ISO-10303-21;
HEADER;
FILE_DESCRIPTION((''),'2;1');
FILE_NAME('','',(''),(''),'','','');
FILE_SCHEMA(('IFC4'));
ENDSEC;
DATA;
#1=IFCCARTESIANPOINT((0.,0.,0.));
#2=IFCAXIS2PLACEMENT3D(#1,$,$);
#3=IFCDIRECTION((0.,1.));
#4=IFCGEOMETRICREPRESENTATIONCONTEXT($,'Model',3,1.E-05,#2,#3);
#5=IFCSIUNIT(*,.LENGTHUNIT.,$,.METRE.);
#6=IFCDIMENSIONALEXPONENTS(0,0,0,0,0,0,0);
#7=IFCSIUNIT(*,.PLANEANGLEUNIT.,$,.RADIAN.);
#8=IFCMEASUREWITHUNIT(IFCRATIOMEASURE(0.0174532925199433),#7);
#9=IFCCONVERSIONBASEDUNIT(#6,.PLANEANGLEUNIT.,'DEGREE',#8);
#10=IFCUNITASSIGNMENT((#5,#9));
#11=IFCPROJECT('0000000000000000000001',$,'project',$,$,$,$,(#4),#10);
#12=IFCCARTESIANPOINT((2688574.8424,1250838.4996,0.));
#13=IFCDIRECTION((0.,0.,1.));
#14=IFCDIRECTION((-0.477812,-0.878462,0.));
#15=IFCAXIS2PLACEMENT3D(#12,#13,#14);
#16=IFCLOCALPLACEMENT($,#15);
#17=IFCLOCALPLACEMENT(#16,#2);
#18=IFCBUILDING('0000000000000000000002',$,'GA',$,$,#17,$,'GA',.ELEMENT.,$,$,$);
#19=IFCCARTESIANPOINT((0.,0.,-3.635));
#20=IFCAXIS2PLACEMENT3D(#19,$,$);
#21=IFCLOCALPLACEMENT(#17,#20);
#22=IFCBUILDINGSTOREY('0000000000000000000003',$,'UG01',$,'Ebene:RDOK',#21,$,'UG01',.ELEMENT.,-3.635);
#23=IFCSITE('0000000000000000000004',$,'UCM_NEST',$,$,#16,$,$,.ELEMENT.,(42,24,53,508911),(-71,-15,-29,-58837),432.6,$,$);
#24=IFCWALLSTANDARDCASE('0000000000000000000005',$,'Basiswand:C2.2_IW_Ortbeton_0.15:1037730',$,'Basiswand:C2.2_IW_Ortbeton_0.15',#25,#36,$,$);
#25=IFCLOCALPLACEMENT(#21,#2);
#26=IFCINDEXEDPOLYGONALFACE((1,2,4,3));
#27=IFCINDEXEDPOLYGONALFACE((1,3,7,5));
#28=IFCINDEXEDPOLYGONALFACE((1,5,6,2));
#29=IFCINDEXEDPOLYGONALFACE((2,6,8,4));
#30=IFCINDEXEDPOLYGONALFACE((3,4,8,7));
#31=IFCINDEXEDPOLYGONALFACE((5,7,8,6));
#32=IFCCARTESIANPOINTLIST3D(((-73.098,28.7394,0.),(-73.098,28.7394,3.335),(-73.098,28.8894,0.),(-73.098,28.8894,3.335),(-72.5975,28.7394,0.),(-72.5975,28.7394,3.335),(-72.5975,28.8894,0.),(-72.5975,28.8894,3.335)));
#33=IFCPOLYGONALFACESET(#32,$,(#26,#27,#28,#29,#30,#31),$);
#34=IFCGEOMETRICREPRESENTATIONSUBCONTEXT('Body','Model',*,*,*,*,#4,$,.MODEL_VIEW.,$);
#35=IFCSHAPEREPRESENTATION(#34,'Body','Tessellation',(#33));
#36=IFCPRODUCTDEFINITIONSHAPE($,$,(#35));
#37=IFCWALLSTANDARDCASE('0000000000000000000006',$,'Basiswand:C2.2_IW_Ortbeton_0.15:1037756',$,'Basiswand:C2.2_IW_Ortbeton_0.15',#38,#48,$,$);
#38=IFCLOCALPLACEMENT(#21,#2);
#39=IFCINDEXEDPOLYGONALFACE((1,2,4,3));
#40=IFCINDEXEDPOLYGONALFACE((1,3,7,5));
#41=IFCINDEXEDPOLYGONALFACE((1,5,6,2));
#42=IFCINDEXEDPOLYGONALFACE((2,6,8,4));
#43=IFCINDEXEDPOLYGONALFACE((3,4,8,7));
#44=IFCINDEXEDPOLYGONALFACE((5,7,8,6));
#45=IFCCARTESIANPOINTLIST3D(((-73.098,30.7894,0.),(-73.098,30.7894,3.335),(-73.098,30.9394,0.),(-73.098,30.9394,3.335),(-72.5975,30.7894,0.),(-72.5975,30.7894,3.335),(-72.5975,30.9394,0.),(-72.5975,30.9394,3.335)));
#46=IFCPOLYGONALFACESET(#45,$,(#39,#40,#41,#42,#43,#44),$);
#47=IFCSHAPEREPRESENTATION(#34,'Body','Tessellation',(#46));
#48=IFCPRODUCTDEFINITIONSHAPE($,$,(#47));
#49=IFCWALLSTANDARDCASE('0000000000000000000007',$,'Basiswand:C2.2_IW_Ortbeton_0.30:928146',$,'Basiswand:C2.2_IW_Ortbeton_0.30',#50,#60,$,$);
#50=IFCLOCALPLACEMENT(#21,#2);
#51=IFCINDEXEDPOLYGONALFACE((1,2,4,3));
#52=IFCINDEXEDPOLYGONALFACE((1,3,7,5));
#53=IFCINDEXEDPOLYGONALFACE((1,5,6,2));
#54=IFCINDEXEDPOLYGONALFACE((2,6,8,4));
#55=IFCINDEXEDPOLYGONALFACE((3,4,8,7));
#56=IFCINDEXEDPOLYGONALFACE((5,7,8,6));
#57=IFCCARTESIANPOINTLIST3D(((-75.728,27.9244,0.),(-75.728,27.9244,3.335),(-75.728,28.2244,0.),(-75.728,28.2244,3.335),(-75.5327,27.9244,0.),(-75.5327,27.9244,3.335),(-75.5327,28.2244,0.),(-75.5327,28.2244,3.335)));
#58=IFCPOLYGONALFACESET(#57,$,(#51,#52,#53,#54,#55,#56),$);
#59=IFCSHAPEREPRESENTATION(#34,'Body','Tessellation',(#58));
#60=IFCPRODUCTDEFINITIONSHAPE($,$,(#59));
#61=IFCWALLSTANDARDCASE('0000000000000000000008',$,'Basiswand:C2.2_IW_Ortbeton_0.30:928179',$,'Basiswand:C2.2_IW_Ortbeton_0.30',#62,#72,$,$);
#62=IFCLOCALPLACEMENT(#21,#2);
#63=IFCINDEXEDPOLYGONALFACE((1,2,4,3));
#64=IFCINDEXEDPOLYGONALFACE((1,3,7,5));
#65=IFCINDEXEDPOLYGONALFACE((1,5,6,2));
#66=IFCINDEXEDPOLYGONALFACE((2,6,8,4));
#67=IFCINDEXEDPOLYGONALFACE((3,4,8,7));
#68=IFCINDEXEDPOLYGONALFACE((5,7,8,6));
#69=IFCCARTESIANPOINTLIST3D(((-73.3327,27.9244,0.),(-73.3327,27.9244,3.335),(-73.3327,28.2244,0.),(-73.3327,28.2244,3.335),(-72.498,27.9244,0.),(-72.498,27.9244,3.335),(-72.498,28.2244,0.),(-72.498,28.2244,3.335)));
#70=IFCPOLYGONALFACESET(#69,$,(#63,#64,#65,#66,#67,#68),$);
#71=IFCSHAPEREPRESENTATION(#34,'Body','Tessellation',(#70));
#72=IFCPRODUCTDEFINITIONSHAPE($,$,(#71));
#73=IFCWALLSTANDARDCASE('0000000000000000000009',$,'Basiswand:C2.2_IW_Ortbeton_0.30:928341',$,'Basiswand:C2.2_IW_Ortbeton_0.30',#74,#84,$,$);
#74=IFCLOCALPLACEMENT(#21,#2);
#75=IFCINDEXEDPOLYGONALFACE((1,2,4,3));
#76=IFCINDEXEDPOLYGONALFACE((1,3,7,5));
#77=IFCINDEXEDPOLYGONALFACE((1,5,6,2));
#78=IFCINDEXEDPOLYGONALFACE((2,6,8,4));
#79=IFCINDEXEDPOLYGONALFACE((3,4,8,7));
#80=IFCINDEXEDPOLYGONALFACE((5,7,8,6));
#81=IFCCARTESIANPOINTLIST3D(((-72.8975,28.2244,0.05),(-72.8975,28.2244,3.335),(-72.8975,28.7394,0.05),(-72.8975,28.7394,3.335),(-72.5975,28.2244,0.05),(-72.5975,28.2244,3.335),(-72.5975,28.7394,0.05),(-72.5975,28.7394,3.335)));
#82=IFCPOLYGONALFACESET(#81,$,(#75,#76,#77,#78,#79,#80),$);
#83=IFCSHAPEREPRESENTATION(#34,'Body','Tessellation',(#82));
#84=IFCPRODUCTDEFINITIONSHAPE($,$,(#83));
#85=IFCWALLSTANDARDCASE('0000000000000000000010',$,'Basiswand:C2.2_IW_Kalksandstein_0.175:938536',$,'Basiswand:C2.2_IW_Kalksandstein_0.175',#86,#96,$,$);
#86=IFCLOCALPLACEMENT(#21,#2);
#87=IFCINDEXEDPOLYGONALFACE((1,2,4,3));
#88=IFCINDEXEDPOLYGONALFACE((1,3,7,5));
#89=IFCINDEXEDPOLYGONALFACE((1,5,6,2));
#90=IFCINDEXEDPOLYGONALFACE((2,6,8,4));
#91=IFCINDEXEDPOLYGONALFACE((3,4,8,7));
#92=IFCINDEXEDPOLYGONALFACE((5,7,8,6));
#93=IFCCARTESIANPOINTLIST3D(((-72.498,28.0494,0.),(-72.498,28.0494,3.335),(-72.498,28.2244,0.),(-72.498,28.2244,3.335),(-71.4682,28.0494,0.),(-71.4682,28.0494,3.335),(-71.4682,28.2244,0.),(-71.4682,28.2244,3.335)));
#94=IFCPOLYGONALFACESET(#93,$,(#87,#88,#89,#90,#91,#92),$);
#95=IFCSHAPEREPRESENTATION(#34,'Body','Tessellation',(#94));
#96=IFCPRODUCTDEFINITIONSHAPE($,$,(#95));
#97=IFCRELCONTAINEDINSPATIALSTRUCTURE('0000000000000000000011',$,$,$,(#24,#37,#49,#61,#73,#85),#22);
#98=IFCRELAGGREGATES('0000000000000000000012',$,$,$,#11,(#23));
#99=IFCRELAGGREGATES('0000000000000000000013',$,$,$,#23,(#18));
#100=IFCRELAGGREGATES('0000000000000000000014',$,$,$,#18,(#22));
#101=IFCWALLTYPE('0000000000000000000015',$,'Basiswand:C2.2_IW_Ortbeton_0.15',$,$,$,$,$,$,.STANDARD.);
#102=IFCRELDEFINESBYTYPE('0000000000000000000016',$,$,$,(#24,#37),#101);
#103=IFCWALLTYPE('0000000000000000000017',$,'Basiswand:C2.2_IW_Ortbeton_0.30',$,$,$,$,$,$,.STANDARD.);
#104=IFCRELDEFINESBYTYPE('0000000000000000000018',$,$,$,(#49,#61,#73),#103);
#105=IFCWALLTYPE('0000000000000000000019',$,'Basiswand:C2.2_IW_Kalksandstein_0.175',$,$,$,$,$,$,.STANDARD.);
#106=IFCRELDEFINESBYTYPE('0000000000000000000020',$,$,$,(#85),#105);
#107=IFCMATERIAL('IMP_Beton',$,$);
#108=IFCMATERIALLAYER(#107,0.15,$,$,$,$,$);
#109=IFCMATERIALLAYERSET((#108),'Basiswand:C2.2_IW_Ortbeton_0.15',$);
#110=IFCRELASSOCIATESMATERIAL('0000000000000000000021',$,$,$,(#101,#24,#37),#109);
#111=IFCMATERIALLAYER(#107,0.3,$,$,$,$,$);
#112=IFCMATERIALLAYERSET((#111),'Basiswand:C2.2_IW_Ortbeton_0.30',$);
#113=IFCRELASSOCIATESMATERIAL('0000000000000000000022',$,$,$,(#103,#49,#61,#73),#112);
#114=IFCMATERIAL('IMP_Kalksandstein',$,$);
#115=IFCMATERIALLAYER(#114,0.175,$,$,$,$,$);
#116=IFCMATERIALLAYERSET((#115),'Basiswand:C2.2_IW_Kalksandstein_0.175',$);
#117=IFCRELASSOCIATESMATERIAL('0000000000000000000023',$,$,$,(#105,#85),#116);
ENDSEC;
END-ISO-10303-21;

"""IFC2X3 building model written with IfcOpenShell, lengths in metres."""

from ifc_helpers import new_model, entity, si_unit, converted_unit, direction, frame, frame_2d, origin, place, context, subcontext, project, spatial, polyline, rectangle, extrude, clip, bounded_halfspace, material, layer, layer_set, layer_usage, type_object, element, save


model = new_model("IFC2X3")

# Units and contexts
model_context = context("Model", 3, precision=1e-05, world=origin(), true_north=direction((0.0, 1.0)))
body_context = subcontext(model_context, "Body", "Model", "MODEL_VIEW")
ifc_project = project(units=[si_unit("LENGTHUNIT", "METRE"), converted_unit("PLANEANGLEUNIT", "DEGREE", entity("IfcRatioMeasure", 0.0174532925199433), si_unit("PLANEANGLEUNIT", "RADIAN"), dimensions=[0, 0, 0, 0, 0, 0, 0])], contexts=[model_context])

# Site, building, storey
site_placement = place(None, frame((2688574.8424, 1250838.4996, 0.0), z_axis=(0.0, 0.0, 1.0), x_axis=(-0.477812, -0.878462, 0.0)))
site = spatial("IfcSite", under=ifc_project, at=site_placement, Name="UCM_NEST", CompositionType="ELEMENT", RefLatitude=(42, 24, 53, 508911), RefLongitude=(-71, -15, -29, -58837), RefElevation=432.6)
building_placement = place(site_placement, origin())
building = spatial("IfcBuilding", under=site, at=building_placement, Name="GA", LongName="GA", CompositionType="ELEMENT")
storey_placement = place(building_placement, frame((0.0, 0.0, -3.635)))
storey = spatial("IfcBuildingStorey", under=building, at=storey_placement, Name="UG01", ObjectType="Ebene:RDOK", LongName="UG01", CompositionType="ELEMENT", Elevation=-3.635)

# Shared definitions
ifc_material_1 = material(Name="IMP_Beton")

# Shared definitions
ifc_layer_1 = layer(ifc_material_1, 0.15)
ifc_layer_set_1 = layer_set([ifc_layer_1], Name="Basiswand:C2.2_IW_Ortbeton_0.15")
wall_type_1 = type_object("IfcWallType", Name="Basiswand:C2.2_IW_Ortbeton_0.15", PredefinedType="STANDARD", material=ifc_layer_set_1)

# Walls
ifc_layer_usage_1 = layer_usage(ifc_layer_set_1, "AXIS2", "NEGATIVE", 0.075)
wall_1_placement = place(storey_placement, frame((-72.5975, 28.8144, 0.0), z_axis=(0.0, 0.0, 1.0), x_axis=(-1.0, 0.0, 0.0)))
element("IfcWallStandardCase", 1, at=wall_1_placement, inside=storey, type_object=wall_type_1, material=ifc_layer_usage_1, Name="Basiswand:C2.2_IW_Ortbeton_0.15:1037730", ObjectType="Basiswand:C2.2_IW_Ortbeton_0.15", context=body_context, shape_type="SweptSolid", body=[
    extrude(rectangle(XDim=0.5005, YDim=0.15, at=frame_2d((0.2503, 0.0), x_axis=(-1.0, 0.0))), origin(), (0.0, 0.0, 1.0), 3.335),
])
ifc_layer_usage_2 = layer_usage(ifc_layer_set_1, "AXIS2", "NEGATIVE", 0.075)
wall_2_placement = place(storey_placement, frame((-73.098, 30.8644, 0.0)))
element("IfcWallStandardCase", 2, at=wall_2_placement, inside=storey, type_object=wall_type_1, material=ifc_layer_usage_2, Name="Basiswand:C2.2_IW_Ortbeton_0.15:1037756", ObjectType="Basiswand:C2.2_IW_Ortbeton_0.15", context=body_context, shape_type="SweptSolid", body=[
    extrude(rectangle(XDim=0.5005, YDim=0.15, at=frame_2d((0.2503, 0.0), x_axis=(-1.0, 0.0))), origin(), (0.0, 0.0, 1.0), 3.335),
])

# Walls
ifc_layer_2 = layer(ifc_material_1, 0.3)
ifc_layer_set_2 = layer_set([ifc_layer_2], Name="Basiswand:C2.2_IW_Ortbeton_0.30")
ifc_layer_usage_3 = layer_usage(ifc_layer_set_2, "AXIS2", "NEGATIVE", 0.15)
wall_type_2 = type_object("IfcWallType", Name="Basiswand:C2.2_IW_Ortbeton_0.30", PredefinedType="STANDARD", material=ifc_layer_set_2)
wall_3_placement = place(storey_placement, frame((-75.728, 28.0744, 0.0)))
element("IfcWallStandardCase", 3, at=wall_3_placement, inside=storey, type_object=wall_type_2, material=ifc_layer_usage_3, Name="Basiswand:C2.2_IW_Ortbeton_0.30:928146", ObjectType="Basiswand:C2.2_IW_Ortbeton_0.30", context=body_context, shape_type="SweptSolid", body=[
    extrude(rectangle(XDim=0.1953, YDim=0.3, at=frame_2d((0.0976, 0.0), x_axis=(-1.0, 0.0))), origin(), (0.0, 0.0, 1.0), 3.335),
])
ifc_layer_usage_4 = layer_usage(ifc_layer_set_2, "AXIS2", "NEGATIVE", 0.15)
wall_4_placement = place(storey_placement, frame((-73.3327, 28.0744, 0.0)))
element("IfcWallStandardCase", 4, at=wall_4_placement, inside=storey, type_object=wall_type_2, material=ifc_layer_usage_4, Name="Basiswand:C2.2_IW_Ortbeton_0.30:928179", ObjectType="Basiswand:C2.2_IW_Ortbeton_0.30", context=body_context, shape_type="SweptSolid", body=[
    extrude(rectangle(XDim=0.8347, YDim=0.3, at=frame_2d((0.4174, 0.0), x_axis=(-1.0, 0.0))), origin(), (0.0, 0.0, 1.0), 3.335),
])
ifc_layer_usage_5 = layer_usage(ifc_layer_set_2, "AXIS2", "NEGATIVE", 0.15)
wall_5_placement = place(storey_placement, frame((-72.7475, 28.7394, 0.05), z_axis=(0.0, 0.0, 1.0), x_axis=(0.0, -1.0, 0.0)))
element("IfcWallStandardCase", 5, at=wall_5_placement, inside=storey, type_object=wall_type_2, material=ifc_layer_usage_5, Name="Basiswand:C2.2_IW_Ortbeton_0.30:928341", ObjectType="Basiswand:C2.2_IW_Ortbeton_0.30", context=body_context, shape_type="Clipping", body=[
    clip(extrude(rectangle(XDim=0.515, YDim=0.3, at=frame_2d((0.2575, 0.0), x_axis=(-1.0, 0.0))), origin(), (0.0, 0.0, 1.0), 3.285), bounded_halfspace(frame((0.515, -0.15, 0.0), z_axis=(0.0, 0.0, 1.0), x_axis=(-1.0, 0.0, 0.0)), True, frame((0.515, -0.15, 0.0), z_axis=(0.0, 0.0, 1.0), x_axis=(-1.0, 0.0, 0.0)), polyline([(0.0, 0.0), (0.0, -0.3), (0.515, -0.3), (0.515, 0.0), (0.0, 0.0)]))),
])
ifc_material_2 = material(Name="IMP_Kalksandstein")
ifc_layer_3 = layer(ifc_material_2, 0.175)
ifc_layer_set_3 = layer_set([ifc_layer_3], Name="Basiswand:C2.2_IW_Kalksandstein_0.175")
ifc_layer_usage_6 = layer_usage(ifc_layer_set_3, "AXIS2", "NEGATIVE", 0.0875)
wall_type_3 = type_object("IfcWallType", Name="Basiswand:C2.2_IW_Kalksandstein_0.175", PredefinedType="STANDARD", material=ifc_layer_set_3)
wall_6_placement = place(storey_placement, frame((-71.4682, 28.1369, 0.0), z_axis=(0.0, 0.0, 1.0), x_axis=(-1.0, 0.0, 0.0)))
element("IfcWallStandardCase", 6, at=wall_6_placement, inside=storey, type_object=wall_type_3, material=ifc_layer_usage_6, Name="Basiswand:C2.2_IW_Kalksandstein_0.175:938536", ObjectType="Basiswand:C2.2_IW_Kalksandstein_0.175", context=body_context, shape_type="SweptSolid", body=[
    extrude(rectangle(XDim=1.0297, YDim=0.175, at=frame_2d((0.5149, 0.0), x_axis=(-1.0, 0.0))), origin(), (0.0, 0.0, 1.0), 3.335),
])

save(model, "model.ifc")
